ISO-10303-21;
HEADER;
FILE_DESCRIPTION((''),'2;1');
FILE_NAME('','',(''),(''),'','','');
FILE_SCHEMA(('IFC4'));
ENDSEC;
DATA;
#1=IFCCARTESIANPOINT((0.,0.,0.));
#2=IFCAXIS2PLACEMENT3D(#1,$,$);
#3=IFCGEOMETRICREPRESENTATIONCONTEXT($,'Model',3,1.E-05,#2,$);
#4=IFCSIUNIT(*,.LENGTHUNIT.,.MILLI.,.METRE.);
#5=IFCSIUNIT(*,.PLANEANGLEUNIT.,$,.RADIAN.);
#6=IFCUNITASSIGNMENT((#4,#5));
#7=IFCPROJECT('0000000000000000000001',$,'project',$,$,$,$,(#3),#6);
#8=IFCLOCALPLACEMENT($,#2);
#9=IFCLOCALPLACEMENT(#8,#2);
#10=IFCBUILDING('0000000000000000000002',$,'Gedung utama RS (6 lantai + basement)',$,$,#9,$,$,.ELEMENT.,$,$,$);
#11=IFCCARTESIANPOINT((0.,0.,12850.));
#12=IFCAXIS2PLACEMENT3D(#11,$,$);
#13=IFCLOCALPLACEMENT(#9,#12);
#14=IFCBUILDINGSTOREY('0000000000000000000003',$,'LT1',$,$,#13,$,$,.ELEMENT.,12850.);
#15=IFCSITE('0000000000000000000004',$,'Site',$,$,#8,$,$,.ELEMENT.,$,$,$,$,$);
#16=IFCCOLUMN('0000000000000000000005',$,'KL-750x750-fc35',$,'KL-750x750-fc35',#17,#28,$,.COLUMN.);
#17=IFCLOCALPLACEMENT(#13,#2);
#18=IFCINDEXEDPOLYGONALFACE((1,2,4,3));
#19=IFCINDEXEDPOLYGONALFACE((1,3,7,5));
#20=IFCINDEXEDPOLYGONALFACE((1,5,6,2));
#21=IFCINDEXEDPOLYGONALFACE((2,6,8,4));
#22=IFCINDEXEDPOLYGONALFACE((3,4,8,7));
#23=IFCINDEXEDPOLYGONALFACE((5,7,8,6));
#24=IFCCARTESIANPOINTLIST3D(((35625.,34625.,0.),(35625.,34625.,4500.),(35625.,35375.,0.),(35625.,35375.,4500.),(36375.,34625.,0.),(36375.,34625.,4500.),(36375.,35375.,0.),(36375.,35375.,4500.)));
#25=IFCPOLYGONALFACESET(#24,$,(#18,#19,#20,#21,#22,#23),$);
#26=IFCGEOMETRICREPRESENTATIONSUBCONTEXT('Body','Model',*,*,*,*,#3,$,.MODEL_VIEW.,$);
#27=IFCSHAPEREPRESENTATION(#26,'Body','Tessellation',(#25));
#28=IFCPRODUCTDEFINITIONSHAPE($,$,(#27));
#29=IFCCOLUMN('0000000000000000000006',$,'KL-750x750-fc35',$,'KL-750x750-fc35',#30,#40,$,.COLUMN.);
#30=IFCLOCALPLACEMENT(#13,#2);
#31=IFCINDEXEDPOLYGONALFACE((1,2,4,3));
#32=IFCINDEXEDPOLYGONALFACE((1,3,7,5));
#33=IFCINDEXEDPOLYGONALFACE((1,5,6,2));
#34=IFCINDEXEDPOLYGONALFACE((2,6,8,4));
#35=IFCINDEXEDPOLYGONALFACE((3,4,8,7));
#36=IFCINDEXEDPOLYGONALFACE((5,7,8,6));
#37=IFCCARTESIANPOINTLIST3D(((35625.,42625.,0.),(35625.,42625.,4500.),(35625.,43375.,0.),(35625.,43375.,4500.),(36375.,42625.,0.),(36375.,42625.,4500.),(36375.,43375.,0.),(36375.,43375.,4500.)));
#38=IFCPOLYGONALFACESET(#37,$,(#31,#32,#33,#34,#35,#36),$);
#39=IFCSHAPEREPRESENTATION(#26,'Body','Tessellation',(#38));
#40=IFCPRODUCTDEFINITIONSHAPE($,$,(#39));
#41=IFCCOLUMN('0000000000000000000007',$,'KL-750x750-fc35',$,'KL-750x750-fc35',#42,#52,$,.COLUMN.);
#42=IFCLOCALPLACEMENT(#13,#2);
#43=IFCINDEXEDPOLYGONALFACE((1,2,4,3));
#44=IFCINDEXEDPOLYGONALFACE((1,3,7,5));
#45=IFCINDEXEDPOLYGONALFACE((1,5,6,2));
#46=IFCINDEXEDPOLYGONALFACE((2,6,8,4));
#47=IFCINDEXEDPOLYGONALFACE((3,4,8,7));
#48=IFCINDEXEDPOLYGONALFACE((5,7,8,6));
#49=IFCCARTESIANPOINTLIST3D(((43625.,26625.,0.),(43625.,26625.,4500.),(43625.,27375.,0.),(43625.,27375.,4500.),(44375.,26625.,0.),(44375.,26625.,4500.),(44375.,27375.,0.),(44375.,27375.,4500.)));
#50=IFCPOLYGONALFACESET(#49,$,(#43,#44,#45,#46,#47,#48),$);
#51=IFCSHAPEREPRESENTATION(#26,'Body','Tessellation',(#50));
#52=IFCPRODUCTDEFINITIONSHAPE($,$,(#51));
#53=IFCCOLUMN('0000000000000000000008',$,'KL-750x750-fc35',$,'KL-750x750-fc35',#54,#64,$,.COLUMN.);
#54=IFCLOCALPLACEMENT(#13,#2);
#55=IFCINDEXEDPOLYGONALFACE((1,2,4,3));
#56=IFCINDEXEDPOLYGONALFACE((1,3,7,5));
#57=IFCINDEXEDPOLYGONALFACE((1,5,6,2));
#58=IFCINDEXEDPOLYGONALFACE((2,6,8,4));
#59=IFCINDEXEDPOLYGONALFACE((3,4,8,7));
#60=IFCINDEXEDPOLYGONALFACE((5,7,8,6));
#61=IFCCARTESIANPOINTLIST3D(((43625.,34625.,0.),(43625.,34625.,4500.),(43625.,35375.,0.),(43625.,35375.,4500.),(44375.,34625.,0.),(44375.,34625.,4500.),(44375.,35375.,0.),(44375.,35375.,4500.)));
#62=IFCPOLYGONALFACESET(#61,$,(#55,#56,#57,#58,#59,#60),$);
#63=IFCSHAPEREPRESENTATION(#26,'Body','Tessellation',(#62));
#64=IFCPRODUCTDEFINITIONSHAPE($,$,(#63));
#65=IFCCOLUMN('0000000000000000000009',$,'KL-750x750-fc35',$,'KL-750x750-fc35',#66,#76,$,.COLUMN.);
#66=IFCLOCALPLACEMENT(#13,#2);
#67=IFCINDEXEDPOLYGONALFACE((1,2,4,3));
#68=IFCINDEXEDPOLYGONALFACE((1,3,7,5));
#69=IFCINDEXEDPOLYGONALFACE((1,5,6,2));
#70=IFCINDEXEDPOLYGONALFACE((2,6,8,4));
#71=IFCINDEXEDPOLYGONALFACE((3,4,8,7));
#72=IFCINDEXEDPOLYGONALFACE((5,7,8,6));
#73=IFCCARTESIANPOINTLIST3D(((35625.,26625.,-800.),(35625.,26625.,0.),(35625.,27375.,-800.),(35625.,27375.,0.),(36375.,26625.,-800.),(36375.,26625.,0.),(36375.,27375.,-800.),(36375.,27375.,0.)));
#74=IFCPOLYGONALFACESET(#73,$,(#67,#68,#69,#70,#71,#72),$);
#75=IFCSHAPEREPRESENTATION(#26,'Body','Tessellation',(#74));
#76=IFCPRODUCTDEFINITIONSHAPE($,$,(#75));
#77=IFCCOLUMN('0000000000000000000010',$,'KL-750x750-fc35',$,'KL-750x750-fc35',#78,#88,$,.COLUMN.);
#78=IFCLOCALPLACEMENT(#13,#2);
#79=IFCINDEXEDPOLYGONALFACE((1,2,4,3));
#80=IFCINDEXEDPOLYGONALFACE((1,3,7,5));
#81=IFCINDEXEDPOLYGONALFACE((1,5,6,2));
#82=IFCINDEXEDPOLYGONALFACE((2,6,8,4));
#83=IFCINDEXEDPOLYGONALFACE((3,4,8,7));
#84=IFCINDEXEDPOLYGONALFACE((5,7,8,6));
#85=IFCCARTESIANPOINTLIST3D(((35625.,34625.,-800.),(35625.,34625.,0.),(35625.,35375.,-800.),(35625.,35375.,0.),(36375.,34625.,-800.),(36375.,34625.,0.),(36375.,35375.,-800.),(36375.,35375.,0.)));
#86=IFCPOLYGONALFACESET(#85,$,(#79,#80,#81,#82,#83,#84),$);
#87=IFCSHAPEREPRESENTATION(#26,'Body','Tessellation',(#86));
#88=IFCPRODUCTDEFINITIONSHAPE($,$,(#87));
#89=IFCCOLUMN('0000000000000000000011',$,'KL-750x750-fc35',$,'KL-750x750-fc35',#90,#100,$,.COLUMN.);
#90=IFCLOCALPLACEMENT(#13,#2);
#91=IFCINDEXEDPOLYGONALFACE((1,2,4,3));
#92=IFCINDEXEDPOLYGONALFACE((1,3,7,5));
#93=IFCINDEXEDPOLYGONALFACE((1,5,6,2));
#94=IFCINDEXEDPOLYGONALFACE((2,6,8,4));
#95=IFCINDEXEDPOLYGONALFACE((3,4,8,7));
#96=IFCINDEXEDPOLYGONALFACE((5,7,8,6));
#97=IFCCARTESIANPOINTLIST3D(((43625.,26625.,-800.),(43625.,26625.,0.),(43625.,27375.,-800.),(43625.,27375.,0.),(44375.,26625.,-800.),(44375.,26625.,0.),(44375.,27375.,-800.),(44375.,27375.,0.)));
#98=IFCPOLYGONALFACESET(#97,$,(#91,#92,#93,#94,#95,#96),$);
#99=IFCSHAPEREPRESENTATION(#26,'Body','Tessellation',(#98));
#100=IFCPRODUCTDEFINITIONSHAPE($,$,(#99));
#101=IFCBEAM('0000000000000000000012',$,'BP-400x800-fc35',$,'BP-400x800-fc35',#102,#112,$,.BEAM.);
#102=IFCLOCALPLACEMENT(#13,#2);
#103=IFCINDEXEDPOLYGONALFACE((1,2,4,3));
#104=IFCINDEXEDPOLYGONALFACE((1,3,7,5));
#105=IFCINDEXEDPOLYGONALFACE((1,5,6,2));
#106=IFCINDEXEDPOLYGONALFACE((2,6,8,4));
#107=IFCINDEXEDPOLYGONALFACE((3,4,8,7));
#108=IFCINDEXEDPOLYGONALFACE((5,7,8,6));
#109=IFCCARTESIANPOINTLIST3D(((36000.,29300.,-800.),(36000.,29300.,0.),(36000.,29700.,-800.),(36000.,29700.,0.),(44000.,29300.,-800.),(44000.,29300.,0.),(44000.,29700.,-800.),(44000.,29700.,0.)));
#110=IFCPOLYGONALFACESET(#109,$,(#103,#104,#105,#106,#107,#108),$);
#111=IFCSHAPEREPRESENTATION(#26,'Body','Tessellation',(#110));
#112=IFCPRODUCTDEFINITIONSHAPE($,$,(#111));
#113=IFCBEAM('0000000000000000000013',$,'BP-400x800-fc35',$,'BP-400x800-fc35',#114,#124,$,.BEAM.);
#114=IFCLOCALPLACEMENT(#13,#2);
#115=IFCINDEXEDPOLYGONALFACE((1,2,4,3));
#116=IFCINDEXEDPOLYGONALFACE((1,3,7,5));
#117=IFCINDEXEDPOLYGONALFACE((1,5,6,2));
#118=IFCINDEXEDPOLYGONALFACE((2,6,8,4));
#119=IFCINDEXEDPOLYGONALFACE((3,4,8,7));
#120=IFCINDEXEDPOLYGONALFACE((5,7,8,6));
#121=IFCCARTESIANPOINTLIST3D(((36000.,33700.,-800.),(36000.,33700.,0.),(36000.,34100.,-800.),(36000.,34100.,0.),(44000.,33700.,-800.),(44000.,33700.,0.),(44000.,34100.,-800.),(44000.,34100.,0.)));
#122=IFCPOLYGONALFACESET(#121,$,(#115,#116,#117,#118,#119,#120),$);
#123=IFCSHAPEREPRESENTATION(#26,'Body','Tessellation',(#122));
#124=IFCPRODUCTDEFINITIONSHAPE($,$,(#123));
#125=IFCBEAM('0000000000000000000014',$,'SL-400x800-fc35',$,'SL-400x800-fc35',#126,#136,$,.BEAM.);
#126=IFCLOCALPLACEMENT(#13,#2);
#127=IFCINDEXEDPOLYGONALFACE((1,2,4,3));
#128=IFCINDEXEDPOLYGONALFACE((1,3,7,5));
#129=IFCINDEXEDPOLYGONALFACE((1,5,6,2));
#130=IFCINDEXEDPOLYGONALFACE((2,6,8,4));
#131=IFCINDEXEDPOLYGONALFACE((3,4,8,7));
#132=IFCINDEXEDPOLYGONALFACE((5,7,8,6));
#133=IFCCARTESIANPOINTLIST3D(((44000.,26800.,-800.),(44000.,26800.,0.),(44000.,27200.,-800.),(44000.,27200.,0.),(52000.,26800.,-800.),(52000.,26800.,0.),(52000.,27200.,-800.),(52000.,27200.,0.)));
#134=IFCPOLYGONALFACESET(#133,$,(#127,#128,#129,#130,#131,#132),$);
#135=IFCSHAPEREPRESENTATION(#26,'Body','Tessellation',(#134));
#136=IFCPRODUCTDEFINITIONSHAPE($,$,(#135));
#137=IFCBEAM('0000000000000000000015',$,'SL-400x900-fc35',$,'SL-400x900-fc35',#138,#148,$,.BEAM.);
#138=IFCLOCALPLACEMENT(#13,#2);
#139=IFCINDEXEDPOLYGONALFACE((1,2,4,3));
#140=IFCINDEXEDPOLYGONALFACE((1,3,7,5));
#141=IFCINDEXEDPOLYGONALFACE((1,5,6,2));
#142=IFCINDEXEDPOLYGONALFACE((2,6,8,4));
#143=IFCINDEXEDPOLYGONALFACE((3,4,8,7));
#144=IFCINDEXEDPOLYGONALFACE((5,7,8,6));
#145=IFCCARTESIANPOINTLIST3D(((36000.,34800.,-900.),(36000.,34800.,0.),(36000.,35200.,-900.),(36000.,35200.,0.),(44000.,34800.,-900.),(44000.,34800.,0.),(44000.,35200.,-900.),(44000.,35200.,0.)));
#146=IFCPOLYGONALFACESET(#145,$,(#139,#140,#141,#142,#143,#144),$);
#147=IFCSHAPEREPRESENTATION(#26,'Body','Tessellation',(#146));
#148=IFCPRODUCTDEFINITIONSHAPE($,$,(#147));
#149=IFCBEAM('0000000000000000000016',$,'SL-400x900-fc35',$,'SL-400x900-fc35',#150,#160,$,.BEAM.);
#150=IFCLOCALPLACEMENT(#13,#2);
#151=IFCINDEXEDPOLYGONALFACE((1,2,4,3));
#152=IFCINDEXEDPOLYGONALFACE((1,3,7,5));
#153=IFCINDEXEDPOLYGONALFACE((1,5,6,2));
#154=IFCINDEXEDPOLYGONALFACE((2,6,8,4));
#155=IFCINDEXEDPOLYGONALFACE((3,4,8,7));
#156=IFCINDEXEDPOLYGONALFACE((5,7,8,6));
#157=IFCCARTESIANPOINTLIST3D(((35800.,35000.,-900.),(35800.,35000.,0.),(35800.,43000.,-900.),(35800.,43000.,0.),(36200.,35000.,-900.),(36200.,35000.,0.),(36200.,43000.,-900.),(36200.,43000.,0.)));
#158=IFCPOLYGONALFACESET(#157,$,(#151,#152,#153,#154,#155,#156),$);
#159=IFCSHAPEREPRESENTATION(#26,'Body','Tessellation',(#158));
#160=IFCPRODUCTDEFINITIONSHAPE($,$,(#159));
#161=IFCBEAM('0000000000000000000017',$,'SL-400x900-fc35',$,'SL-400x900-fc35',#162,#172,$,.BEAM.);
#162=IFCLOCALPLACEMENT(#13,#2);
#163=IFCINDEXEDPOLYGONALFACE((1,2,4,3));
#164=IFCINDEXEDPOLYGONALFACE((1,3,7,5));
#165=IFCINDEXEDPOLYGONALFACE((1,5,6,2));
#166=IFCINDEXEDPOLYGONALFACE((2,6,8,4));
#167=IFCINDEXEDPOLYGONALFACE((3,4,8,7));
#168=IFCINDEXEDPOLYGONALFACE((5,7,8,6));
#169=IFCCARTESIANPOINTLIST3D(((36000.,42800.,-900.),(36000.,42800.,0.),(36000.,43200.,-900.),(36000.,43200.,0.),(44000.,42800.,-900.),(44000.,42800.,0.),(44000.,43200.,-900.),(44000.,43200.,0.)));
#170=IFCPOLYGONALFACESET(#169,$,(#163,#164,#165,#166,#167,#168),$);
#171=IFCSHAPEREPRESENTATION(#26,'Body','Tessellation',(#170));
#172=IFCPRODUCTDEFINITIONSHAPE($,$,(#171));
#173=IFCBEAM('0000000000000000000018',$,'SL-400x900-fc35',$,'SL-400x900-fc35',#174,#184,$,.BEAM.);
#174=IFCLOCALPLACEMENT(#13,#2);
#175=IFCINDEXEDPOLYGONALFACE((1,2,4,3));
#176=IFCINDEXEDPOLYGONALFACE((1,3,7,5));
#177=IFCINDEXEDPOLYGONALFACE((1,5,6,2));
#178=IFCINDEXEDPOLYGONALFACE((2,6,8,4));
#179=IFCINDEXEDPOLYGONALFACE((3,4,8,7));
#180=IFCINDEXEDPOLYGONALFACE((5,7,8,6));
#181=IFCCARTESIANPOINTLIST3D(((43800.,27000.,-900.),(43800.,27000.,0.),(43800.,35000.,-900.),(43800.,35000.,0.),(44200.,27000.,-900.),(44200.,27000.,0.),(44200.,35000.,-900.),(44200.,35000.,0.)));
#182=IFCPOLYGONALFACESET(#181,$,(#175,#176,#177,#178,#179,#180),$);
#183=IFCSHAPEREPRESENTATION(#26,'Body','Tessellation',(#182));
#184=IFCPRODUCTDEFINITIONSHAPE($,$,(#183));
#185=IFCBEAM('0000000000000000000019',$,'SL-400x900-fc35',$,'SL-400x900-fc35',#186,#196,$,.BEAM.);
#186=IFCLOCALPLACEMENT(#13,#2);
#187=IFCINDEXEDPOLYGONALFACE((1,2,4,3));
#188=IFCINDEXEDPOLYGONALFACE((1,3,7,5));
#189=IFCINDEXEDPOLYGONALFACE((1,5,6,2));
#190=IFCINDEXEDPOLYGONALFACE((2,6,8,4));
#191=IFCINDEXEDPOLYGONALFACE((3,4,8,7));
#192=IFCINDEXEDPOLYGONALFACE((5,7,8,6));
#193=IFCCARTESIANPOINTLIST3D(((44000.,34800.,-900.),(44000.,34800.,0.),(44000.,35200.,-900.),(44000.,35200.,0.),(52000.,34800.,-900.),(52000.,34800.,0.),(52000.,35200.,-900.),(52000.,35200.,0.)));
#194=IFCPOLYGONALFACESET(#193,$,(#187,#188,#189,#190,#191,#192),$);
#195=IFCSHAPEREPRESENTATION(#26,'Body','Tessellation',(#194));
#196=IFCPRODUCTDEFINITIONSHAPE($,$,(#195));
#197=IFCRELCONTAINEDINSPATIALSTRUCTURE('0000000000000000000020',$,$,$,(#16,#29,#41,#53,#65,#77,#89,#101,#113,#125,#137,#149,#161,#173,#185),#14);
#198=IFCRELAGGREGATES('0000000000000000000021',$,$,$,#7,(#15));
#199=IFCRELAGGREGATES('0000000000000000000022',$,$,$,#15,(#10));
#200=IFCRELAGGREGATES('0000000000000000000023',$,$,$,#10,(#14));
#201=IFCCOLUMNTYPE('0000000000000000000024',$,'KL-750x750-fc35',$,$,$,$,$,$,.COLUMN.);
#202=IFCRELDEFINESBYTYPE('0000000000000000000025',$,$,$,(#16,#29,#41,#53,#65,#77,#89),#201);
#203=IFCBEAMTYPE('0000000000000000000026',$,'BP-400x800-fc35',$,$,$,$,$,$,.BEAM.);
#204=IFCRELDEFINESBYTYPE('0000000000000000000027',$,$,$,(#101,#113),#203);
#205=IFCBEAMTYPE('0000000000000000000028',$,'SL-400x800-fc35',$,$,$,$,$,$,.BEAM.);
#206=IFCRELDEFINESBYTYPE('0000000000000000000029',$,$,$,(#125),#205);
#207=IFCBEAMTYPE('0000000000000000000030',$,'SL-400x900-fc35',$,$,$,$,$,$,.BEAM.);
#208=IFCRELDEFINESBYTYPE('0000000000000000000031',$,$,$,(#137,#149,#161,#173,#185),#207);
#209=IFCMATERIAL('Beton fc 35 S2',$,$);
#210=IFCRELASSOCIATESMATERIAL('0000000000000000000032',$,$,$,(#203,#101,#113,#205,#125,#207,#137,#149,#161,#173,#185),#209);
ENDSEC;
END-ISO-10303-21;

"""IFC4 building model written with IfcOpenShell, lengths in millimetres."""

from ifc_helpers import new_model, si_unit, frame, origin, origin_2d, place, context, subcontext, project, spatial, rectangle, extrude, material, material_profile, profile_set, profile_usage, type_object, element, save


model = new_model("IFC4")

# Units and contexts
model_context = context("Model", 3, precision=1e-05, world=origin())
body_context = subcontext(model_context, "Body", "Model", "MODEL_VIEW")
ifc_project = project(units=[si_unit("LENGTHUNIT", "METRE", prefix="MILLI"), si_unit("PLANEANGLEUNIT", "RADIAN")], contexts=[model_context])

# Site, building, storey
site_placement = place(None, origin())
site = spatial("IfcSite", under=ifc_project, at=site_placement, Name="Site", CompositionType="ELEMENT")
building_placement = place(site_placement, origin())
building = spatial("IfcBuilding", under=site, at=building_placement, Name="Gedung utama RS (6 lantai + basement)", CompositionType="ELEMENT")
storey_placement = place(building_placement, frame((0.0, 0.0, 12850.0)))
storey = spatial("IfcBuildingStorey", under=building, at=storey_placement, Name="LT1", CompositionType="ELEMENT", Elevation=12850.0)

# Columns
ifc_material_profile_1 = material_profile(None, rectangle(XDim=750.0, YDim=750.0, at=origin_2d()), Name="KL-750x750-fc35")
ifc_profile_set_1 = profile_set([ifc_material_profile_1], Name="KL-750x750-fc35")
ifc_profile_usage_1 = profile_usage(ifc_profile_set_1, cardinal=5)
column_type = type_object("IfcColumnType", Name="KL-750x750-fc35", PredefinedType="COLUMN", material=ifc_profile_set_1)
for number, where, z_axis, x_axis, name in (
    (1, (36000.0, 35000.0, 0.0), (0.0, 0.0, 1.0), (1.0, 0.0, 0.0), "KL-750x750-fc35"),
    (2, (36000.0, 43000.0, 0.0), (0.0, 0.0, 1.0), (1.0, 0.0, 0.0), "KL-750x750-fc35"),
    (3, (44000.0, 27000.0, 0.0), (0.0, 0.0, 1.0), (1.0, 0.0, 0.0), "KL-750x750-fc35"),
    (4, (44000.0, 35000.0, 0.0), (0.0, 0.0, 1.0), (1.0, 0.0, 0.0), "KL-750x750-fc35"),
):
    element("IfcColumn", number, at=place(storey_placement, frame(where, z_axis=z_axis, x_axis=x_axis)), inside=storey, type_object=column_type, material=ifc_profile_usage_1, Name=name, ObjectType="KL-750x750-fc35", PredefinedType="COLUMN", context=body_context, shape_type="SweptSolid", body=[
        extrude(rectangle(XDim=750.0, YDim=750.0, at=origin_2d()), origin(), (0.0, 0.0, 1.0), 4500.0),
    ])
for number, where, z_axis, x_axis, name in (
    (5, (36000.0, 27000.0, -800.0), (0.0, 0.0, 1.0), (1.0, 0.0, 0.0), "KL-750x750-fc35"),
    (6, (36000.0, 35000.0, -800.0), (0.0, 0.0, 1.0), (1.0, 0.0, 0.0), "KL-750x750-fc35"),
    (7, (44000.0, 27000.0, -800.0), (0.0, 0.0, 1.0), (1.0, 0.0, 0.0), "KL-750x750-fc35"),
):
    element("IfcColumn", number, at=place(storey_placement, frame(where, z_axis=z_axis, x_axis=x_axis)), inside=storey, type_object=column_type, material=ifc_profile_usage_1, Name=name, ObjectType="KL-750x750-fc35", PredefinedType="COLUMN", context=body_context, shape_type="SweptSolid", body=[
        extrude(rectangle(XDim=750.0, YDim=750.0, at=origin_2d()), origin(), (0.0, 0.0, 1.0), 800.0),
    ])

# Beams
ifc_material = material(Name="Beton fc 35 S2")
ifc_material_profile_2 = material_profile(ifc_material, rectangle(XDim=400.0, YDim=800.0, at=origin_2d()), Name="BP-400x800-fc35")
ifc_profile_set_2 = profile_set([ifc_material_profile_2], Name="BP-400x800-fc35")
ifc_profile_usage_2 = profile_usage(ifc_profile_set_2, cardinal=8)
beam_type_1 = type_object("IfcBeamType", Name="BP-400x800-fc35", PredefinedType="BEAM", material=ifc_profile_set_2)
for number, where, name in (
    (8, (36000.0, 29500.0, -400.0), "BP-400x800-fc35"),
    (9, (36000.0, 33900.0, -400.0), "BP-400x800-fc35"),
):
    element("IfcBeam", number, at=place(storey_placement, frame(where)), inside=storey, type_object=beam_type_1, material=ifc_profile_usage_2, Name=name, ObjectType="BP-400x800-fc35", PredefinedType="BEAM", context=body_context, shape_type="SweptSolid", body=[
        extrude(rectangle(XDim=400.0, YDim=800.0, at=origin_2d()), frame((0.0, 0.0, 0.0), z_axis=(1.0, 0.0, 0.0), x_axis=(0.0, 1.0, 0.0)), (0.0, 0.0, 1.0), 8000.0),
    ])
ifc_material_profile_3 = material_profile(ifc_material, rectangle(XDim=400.0, YDim=800.0, at=origin_2d()), Name="SL-400x800-fc35")
ifc_profile_set_3 = profile_set([ifc_material_profile_3], Name="SL-400x800-fc35")
ifc_profile_usage_3 = profile_usage(ifc_profile_set_3, cardinal=8)
beam_type_2 = type_object("IfcBeamType", Name="SL-400x800-fc35", PredefinedType="BEAM", material=ifc_profile_set_3)
beam_1_placement = place(storey_placement, frame((44000.0, 27000.0, -400.0)))
element("IfcBeam", 10, at=beam_1_placement, inside=storey, type_object=beam_type_2, material=ifc_profile_usage_3, Name="SL-400x800-fc35", ObjectType="SL-400x800-fc35", PredefinedType="BEAM", context=body_context, shape_type="SweptSolid", body=[
    extrude(rectangle(XDim=400.0, YDim=800.0, at=origin_2d()), frame((0.0, 0.0, 0.0), z_axis=(1.0, 0.0, 0.0), x_axis=(0.0, 1.0, 0.0)), (0.0, 0.0, 1.0), 8000.0),
])
ifc_material_profile_4 = material_profile(ifc_material, rectangle(XDim=400.0, YDim=900.0, at=origin_2d()), Name="SL-400x900-fc35")
ifc_profile_set_4 = profile_set([ifc_material_profile_4], Name="SL-400x900-fc35")
ifc_profile_usage_4 = profile_usage(ifc_profile_set_4, cardinal=8)
beam_type_3 = type_object("IfcBeamType", Name="SL-400x900-fc35", PredefinedType="BEAM", material=ifc_profile_set_4)
beam_2_placement = place(storey_placement, frame((36000.0, 35000.0, -450.0)))
element("IfcBeam", 11, at=beam_2_placement, inside=storey, type_object=beam_type_3, material=ifc_profile_usage_4, Name="SL-400x900-fc35", ObjectType="SL-400x900-fc35", PredefinedType="BEAM", context=body_context, shape_type="SweptSolid", body=[
    extrude(rectangle(XDim=400.0, YDim=900.0, at=origin_2d()), frame((0.0, 0.0, 0.0), z_axis=(1.0, 0.0, 0.0), x_axis=(0.0, 1.0, 0.0)), (0.0, 0.0, 1.0), 8000.0),
])
beam_3_placement = place(storey_placement, frame((36000.0, 35000.0, -450.0)))
element("IfcBeam", 12, at=beam_3_placement, inside=storey, type_object=beam_type_3, material=ifc_profile_usage_4, Name="SL-400x900-fc35", ObjectType="SL-400x900-fc35", PredefinedType="BEAM", context=body_context, shape_type="SweptSolid", body=[
    extrude(rectangle(XDim=400.0, YDim=900.0, at=origin_2d()), frame((0.0, 0.0, 0.0), z_axis=(0.0, 1.0, 0.0), x_axis=(-1.0, 0.0, 0.0)), (0.0, 0.0, 1.0), 8000.0),
])
beam_4_placement = place(storey_placement, frame((36000.0, 43000.0, -450.0)))
element("IfcBeam", 13, at=beam_4_placement, inside=storey, type_object=beam_type_3, material=ifc_profile_usage_4, Name="SL-400x900-fc35", ObjectType="SL-400x900-fc35", PredefinedType="BEAM", context=body_context, shape_type="SweptSolid", body=[
    extrude(rectangle(XDim=400.0, YDim=900.0, at=origin_2d()), frame((0.0, 0.0, 0.0), z_axis=(1.0, 0.0, 0.0), x_axis=(0.0, 1.0, 0.0)), (0.0, 0.0, 1.0), 8000.0),
])
beam_5_placement = place(storey_placement, frame((44000.0, 27000.0, -450.0)))
element("IfcBeam", 14, at=beam_5_placement, inside=storey, type_object=beam_type_3, material=ifc_profile_usage_4, Name="SL-400x900-fc35", ObjectType="SL-400x900-fc35", PredefinedType="BEAM", context=body_context, shape_type="SweptSolid", body=[
    extrude(rectangle(XDim=400.0, YDim=900.0, at=origin_2d()), frame((0.0, 0.0, 0.0), z_axis=(0.0, 1.0, 0.0), x_axis=(-1.0, 0.0, 0.0)), (0.0, 0.0, 1.0), 8000.0),
])
beam_6_placement = place(storey_placement, frame((44000.0, 35000.0, -450.0)))
element("IfcBeam", 15, at=beam_6_placement, inside=storey, type_object=beam_type_3, material=ifc_profile_usage_4, Name="SL-400x900-fc35", ObjectType="SL-400x900-fc35", PredefinedType="BEAM", context=body_context, shape_type="SweptSolid", body=[
    extrude(rectangle(XDim=400.0, YDim=900.0, at=origin_2d()), frame((0.0, 0.0, 0.0), z_axis=(1.0, 0.0, 0.0), x_axis=(0.0, 1.0, 0.0)), (0.0, 0.0, 1.0), 8000.0),
])

save(model, "model.ifc")
